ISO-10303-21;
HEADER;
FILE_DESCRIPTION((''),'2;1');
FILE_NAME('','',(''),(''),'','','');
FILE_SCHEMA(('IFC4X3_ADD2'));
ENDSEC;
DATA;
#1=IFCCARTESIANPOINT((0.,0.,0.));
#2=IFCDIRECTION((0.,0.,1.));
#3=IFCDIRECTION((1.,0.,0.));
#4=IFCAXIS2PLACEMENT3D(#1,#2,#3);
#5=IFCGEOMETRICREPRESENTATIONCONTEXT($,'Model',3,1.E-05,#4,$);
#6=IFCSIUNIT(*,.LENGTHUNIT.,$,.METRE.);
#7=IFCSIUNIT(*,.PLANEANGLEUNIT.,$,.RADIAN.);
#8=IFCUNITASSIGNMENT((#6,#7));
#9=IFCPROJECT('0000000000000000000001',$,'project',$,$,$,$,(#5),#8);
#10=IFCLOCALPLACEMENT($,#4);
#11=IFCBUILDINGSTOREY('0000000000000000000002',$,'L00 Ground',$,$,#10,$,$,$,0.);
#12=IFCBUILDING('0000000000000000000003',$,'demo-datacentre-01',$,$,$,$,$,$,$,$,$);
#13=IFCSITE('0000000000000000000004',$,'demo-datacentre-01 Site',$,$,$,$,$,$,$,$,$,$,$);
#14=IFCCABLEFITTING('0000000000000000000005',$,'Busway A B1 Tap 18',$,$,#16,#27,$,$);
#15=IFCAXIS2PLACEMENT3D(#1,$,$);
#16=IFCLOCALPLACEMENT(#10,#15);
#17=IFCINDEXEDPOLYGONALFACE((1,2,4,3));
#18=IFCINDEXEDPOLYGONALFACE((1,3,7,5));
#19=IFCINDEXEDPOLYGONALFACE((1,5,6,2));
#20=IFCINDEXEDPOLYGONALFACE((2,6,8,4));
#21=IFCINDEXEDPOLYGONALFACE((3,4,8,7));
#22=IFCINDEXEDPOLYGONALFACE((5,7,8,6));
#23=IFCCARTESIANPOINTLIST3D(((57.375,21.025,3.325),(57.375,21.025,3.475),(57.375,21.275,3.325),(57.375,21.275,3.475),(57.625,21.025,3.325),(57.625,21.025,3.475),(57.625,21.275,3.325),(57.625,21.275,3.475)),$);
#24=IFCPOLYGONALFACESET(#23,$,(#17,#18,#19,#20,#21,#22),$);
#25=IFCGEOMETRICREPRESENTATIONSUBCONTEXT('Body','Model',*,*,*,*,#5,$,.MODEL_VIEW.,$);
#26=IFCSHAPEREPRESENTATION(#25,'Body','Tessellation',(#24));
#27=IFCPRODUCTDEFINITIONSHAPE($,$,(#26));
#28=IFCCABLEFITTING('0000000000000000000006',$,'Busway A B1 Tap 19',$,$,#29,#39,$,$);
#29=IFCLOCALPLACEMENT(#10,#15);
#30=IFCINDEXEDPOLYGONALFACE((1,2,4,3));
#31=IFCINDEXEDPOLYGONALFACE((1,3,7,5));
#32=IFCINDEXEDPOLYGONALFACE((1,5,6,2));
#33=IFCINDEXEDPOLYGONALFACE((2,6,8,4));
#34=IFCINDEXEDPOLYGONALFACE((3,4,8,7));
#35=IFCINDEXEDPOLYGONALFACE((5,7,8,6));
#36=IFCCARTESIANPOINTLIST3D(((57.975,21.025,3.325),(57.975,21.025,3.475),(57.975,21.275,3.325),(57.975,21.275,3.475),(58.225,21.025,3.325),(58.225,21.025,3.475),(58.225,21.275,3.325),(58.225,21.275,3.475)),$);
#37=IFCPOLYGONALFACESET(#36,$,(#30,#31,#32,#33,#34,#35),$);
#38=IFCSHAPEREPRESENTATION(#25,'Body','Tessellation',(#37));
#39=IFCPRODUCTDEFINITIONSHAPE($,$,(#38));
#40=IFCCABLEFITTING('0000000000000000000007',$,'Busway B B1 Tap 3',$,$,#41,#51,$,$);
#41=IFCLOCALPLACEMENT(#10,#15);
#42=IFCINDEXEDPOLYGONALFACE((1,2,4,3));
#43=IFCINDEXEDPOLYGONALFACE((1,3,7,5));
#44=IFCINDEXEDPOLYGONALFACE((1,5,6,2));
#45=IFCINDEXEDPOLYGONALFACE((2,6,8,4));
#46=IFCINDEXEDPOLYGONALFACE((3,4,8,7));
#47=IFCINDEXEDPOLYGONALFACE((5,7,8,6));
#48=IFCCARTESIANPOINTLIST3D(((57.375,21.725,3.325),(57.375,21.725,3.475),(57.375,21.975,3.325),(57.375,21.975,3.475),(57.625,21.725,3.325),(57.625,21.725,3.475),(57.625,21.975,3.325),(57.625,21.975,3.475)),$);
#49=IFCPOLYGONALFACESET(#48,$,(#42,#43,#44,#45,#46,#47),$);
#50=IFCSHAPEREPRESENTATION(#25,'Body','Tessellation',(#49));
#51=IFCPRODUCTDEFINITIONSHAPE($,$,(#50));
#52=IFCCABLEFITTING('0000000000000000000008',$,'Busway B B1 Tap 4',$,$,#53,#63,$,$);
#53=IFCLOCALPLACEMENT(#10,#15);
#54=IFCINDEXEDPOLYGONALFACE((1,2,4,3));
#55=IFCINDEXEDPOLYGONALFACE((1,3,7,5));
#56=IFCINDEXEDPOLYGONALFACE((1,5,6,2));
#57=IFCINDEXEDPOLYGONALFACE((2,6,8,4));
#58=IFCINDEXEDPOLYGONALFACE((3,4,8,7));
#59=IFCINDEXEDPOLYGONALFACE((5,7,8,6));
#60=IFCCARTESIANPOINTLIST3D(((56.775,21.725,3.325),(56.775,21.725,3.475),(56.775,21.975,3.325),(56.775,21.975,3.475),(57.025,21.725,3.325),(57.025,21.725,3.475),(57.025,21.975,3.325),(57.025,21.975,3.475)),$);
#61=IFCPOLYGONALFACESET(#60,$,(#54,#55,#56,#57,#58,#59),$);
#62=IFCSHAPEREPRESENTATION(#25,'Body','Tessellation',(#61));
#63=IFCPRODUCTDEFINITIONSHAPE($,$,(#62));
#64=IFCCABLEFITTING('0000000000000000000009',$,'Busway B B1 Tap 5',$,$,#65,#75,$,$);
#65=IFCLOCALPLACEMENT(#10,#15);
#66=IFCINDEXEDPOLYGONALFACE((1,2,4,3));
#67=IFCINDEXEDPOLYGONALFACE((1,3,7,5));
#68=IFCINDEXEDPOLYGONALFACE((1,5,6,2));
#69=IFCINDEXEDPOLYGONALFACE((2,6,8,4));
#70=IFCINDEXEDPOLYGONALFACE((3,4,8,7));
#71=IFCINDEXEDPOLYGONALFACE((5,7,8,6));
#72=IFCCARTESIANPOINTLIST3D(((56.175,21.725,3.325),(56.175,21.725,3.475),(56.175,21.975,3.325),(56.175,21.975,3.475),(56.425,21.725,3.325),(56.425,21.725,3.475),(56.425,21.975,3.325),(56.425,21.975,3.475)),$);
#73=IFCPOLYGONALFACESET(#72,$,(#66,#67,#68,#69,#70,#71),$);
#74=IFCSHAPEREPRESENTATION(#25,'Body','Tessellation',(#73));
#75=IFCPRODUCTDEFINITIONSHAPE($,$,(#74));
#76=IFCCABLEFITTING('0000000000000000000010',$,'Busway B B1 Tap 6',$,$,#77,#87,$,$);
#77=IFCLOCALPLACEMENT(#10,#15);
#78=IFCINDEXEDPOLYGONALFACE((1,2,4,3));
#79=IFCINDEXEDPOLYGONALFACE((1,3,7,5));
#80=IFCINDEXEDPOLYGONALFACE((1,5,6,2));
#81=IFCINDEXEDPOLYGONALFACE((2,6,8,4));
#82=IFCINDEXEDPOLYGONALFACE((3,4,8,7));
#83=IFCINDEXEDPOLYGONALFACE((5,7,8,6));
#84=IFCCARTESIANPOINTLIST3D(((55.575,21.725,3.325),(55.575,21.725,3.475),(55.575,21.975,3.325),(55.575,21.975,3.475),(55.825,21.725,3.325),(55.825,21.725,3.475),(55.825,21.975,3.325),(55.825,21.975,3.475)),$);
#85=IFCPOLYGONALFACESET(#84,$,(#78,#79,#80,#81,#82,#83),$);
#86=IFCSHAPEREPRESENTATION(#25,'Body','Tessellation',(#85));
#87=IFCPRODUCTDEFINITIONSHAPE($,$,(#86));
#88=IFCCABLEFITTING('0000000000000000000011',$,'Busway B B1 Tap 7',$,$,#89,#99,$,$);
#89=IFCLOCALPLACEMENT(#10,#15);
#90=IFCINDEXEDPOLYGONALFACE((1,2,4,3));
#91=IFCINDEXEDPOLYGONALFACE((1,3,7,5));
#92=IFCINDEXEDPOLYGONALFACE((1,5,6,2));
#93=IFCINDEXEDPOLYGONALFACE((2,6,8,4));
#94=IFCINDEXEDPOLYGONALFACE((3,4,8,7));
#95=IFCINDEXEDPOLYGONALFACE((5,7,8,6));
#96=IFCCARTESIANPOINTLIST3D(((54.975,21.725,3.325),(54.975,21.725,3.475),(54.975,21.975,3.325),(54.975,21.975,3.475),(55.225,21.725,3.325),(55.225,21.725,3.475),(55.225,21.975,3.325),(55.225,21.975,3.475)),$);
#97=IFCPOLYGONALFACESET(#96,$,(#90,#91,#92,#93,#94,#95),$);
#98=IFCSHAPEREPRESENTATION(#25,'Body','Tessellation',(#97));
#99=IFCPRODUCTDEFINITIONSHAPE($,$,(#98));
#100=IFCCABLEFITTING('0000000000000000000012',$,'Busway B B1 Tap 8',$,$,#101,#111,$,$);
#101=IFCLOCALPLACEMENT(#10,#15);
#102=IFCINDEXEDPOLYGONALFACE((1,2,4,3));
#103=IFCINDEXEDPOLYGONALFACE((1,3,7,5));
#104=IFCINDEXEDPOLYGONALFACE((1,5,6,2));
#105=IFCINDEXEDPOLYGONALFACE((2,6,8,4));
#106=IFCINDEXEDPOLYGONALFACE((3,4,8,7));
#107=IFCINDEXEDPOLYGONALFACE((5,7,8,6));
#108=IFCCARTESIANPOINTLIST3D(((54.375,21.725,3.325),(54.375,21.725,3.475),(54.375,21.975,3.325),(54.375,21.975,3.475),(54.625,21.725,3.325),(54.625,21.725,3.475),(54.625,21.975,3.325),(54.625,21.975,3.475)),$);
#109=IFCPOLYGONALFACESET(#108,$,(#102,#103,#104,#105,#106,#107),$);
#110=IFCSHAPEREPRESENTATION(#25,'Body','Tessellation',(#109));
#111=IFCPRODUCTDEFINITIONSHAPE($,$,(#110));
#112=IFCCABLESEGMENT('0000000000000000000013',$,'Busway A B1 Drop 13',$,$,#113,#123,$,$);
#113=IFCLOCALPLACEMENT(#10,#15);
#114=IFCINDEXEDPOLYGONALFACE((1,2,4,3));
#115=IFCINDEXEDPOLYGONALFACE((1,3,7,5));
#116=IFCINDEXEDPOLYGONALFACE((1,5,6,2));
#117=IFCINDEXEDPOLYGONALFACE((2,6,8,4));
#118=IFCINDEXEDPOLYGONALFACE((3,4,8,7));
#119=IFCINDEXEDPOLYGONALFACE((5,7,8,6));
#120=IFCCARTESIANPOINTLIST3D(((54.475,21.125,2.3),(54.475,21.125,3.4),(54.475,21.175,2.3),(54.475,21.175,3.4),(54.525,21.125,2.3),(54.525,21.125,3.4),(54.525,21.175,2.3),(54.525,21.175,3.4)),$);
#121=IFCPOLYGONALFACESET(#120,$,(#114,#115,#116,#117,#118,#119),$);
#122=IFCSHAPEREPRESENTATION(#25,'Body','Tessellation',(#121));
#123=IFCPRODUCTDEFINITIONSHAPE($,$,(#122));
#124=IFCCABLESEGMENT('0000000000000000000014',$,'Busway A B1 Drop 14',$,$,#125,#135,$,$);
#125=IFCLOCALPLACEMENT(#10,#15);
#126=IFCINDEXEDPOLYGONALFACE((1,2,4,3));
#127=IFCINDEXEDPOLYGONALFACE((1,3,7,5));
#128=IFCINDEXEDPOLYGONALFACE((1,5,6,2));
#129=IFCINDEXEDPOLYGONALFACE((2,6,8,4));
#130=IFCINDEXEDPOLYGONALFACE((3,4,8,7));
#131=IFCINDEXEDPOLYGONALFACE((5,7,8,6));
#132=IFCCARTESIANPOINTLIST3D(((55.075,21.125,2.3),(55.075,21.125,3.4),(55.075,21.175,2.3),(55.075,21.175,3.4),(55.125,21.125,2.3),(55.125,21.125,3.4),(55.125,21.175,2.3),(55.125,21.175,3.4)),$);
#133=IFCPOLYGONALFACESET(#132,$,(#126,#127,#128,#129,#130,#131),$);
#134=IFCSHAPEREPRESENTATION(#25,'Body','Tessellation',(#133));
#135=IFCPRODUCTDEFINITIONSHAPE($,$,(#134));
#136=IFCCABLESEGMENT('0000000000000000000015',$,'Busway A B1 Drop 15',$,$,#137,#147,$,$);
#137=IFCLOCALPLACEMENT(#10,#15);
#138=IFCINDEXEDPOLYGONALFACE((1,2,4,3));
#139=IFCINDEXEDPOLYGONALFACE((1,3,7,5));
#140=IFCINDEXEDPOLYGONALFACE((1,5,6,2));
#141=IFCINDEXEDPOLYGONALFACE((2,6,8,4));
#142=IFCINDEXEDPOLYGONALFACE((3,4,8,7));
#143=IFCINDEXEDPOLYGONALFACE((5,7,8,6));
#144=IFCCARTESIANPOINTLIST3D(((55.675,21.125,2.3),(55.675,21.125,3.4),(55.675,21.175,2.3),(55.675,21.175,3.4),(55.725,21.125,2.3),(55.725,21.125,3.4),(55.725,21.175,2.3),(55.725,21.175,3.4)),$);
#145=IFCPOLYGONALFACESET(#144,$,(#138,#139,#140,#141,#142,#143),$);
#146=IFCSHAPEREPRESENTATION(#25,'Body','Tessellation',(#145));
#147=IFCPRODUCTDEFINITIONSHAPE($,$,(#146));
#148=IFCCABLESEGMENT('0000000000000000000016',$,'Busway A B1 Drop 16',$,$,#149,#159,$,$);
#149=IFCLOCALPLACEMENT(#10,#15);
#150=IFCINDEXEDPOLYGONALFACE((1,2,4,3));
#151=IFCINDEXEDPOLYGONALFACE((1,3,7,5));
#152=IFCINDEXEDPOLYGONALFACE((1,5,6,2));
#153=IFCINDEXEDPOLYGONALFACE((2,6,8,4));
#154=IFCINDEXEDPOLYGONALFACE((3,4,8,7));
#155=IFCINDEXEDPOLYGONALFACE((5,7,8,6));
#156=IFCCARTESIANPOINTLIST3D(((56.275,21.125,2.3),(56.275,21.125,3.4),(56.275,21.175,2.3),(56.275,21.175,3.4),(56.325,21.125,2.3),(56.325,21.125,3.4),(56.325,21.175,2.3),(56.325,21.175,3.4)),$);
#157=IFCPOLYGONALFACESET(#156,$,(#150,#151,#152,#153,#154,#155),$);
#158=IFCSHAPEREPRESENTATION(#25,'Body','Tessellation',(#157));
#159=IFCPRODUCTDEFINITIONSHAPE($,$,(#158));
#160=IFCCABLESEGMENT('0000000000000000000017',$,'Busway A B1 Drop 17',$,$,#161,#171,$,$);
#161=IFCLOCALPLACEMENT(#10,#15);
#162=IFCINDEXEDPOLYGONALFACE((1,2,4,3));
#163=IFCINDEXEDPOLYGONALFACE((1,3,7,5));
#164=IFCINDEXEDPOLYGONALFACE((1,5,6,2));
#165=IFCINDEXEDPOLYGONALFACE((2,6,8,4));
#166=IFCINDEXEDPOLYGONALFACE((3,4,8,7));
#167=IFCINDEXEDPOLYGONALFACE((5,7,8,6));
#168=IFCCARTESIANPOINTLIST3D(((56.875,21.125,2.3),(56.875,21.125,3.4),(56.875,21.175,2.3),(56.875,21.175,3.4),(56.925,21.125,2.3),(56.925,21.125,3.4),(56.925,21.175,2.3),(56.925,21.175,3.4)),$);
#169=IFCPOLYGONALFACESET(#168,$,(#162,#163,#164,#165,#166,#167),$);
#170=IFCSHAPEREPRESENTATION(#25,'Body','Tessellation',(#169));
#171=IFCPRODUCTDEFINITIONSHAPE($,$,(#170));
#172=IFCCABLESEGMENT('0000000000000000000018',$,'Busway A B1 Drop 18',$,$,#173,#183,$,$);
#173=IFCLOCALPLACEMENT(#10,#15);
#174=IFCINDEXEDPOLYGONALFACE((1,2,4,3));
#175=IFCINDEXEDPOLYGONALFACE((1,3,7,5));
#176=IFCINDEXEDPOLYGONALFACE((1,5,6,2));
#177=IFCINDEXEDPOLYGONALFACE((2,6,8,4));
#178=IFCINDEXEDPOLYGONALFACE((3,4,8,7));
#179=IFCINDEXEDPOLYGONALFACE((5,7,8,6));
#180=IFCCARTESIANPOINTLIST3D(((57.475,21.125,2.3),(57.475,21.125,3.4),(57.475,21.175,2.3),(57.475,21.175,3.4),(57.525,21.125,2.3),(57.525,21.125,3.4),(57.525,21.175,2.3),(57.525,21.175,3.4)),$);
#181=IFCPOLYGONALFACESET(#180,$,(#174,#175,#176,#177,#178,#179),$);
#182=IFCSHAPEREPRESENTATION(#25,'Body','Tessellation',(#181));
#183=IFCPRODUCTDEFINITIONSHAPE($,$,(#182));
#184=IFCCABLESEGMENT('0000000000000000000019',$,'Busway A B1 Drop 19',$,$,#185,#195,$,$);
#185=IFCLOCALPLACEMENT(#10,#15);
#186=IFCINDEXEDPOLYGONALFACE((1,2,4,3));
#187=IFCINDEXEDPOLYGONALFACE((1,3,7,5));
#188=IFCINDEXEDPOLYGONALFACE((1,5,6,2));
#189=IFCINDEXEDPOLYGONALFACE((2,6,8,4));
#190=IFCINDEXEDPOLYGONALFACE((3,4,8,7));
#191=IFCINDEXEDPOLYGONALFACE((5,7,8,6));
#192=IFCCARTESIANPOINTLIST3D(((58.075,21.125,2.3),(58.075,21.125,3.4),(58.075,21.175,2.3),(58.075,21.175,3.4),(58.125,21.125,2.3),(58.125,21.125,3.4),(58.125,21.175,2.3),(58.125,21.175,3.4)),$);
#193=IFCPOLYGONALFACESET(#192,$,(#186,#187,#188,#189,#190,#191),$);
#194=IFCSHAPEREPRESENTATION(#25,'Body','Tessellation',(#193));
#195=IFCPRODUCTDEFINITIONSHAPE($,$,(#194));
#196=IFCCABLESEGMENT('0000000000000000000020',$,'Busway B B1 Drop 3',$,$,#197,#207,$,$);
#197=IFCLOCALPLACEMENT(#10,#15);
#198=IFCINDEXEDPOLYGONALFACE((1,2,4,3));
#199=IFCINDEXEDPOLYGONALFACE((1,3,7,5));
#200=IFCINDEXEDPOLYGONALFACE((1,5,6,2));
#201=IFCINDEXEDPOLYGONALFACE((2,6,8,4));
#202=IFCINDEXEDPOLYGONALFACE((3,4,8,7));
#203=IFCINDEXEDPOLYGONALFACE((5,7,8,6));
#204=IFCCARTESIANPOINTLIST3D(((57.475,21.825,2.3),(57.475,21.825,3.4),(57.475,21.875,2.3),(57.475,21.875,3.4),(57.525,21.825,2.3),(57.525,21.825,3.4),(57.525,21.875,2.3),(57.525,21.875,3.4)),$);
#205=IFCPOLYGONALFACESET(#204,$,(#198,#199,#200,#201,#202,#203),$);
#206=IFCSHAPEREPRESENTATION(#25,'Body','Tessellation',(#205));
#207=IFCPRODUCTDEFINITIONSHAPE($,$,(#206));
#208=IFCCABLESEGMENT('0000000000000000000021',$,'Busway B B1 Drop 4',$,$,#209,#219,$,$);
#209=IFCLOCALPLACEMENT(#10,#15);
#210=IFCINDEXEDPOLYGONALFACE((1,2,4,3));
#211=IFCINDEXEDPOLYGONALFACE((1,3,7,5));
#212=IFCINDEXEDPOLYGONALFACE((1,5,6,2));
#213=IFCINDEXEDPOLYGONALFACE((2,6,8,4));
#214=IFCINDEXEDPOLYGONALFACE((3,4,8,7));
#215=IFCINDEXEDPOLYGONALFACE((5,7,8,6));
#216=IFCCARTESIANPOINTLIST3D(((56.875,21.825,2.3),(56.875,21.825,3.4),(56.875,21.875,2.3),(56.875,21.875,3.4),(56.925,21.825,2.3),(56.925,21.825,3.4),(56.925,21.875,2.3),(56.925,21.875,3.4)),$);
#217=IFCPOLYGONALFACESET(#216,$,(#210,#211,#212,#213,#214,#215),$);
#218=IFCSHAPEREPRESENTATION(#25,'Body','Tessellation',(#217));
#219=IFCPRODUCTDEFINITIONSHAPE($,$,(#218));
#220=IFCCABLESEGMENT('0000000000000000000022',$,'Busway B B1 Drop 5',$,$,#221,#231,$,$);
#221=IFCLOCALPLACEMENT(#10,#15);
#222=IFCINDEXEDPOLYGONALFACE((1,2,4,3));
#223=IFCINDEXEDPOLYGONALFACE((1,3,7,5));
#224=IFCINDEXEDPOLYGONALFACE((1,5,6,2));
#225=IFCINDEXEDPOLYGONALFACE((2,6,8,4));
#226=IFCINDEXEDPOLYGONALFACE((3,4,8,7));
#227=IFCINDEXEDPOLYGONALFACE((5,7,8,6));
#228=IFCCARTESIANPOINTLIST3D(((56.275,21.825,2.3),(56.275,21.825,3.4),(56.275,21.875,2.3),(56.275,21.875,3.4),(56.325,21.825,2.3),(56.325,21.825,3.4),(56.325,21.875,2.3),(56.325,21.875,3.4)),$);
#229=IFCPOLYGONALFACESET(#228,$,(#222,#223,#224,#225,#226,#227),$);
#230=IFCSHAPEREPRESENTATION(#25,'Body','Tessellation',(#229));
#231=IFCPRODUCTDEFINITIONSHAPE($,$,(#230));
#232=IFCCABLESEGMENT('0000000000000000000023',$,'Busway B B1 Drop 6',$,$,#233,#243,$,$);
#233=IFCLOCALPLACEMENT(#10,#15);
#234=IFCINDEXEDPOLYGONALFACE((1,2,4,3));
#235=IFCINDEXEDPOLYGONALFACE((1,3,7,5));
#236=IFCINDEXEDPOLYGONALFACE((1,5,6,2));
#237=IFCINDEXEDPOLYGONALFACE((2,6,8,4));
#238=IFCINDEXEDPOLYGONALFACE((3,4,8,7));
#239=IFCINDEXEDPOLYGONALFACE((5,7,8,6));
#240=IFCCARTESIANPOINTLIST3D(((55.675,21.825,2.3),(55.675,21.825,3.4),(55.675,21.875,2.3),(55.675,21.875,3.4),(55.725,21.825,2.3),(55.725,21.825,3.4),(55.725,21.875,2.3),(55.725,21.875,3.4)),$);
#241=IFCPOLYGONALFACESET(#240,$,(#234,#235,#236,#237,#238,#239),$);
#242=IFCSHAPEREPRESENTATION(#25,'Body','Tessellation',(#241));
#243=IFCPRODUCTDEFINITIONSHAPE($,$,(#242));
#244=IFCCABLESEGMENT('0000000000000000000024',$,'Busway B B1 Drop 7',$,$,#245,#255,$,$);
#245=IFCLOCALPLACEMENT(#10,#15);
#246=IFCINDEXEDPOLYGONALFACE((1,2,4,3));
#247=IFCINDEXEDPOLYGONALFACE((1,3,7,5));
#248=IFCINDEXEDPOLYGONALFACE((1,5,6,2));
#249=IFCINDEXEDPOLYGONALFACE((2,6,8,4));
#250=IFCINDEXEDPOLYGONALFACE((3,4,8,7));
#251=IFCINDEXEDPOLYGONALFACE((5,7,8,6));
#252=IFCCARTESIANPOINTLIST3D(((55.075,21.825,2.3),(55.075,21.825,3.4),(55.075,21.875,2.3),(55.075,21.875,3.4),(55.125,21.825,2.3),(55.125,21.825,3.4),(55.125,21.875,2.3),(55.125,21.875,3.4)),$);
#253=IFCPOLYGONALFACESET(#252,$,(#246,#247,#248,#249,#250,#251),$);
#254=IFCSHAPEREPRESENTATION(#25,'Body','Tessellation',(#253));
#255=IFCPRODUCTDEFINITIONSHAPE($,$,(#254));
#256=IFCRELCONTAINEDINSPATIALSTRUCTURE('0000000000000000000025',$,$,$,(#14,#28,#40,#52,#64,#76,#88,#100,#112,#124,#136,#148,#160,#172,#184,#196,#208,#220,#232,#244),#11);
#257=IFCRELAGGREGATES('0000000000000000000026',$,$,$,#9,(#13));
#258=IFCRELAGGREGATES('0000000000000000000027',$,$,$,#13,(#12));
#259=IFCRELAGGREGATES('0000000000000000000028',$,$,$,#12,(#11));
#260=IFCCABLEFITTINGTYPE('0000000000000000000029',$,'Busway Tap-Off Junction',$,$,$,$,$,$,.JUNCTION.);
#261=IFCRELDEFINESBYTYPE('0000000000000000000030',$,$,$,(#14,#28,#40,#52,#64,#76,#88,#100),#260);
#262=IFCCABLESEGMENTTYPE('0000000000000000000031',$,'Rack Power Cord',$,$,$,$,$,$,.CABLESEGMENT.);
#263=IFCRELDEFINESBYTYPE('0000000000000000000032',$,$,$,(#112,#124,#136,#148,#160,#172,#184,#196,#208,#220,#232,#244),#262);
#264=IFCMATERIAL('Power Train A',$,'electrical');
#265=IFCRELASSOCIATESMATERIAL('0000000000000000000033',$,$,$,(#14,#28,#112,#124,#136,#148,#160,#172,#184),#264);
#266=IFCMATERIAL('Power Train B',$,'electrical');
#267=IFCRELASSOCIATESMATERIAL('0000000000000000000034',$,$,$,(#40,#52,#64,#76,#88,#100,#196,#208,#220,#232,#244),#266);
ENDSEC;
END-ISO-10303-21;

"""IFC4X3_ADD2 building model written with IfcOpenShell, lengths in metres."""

from ifc_helpers import new_model, si_unit, frame, origin_with_axes, place, context, subcontext, project, spatial, rectangle, extrude, material, type_object, element, save


model = new_model("IFC4X3_ADD2")

# Units and contexts
model_context = context("Model", 3, precision=1e-05, world=origin_with_axes())
body_context = subcontext(model_context, "Body", "Model", "MODEL_VIEW")
ifc_project = project(units=[si_unit("LENGTHUNIT", "METRE"), si_unit("PLANEANGLEUNIT", "RADIAN")], contexts=[model_context])

# Site, building, storey
site = spatial("IfcSite", under=ifc_project, Name="demo-datacentre-01 Site")
building = spatial("IfcBuilding", under=site, Name="demo-datacentre-01")
storey_placement = place(None, origin_with_axes())
storey = spatial("IfcBuildingStorey", under=building, at=storey_placement, Name="L00 Ground", Elevation=0.0)

# Shared definitions
ifc_material_1 = material(Name="Power Train A", Category="electrical")
ifc_material_2 = material(Name="Power Train B", Category="electrical")

# Cable fittings
cable_fitting_type = type_object("IfcCableFittingType", Name="Busway Tap-Off Junction", PredefinedType="JUNCTION")
for number, where, z_axis, x_axis, name in (
    (1, (57.5, 21.15, 3.325), (0.0, 0.0, 1.0), (1.0, 0.0, 0.0), "Busway A B1 Tap 18"),
    (2, (58.1, 21.15, 3.325), (0.0, 0.0, 1.0), (1.0, 0.0, 0.0), "Busway A B1 Tap 19"),
):
    element("IfcCableFitting", number, at=place(storey_placement, frame(where, z_axis=z_axis, x_axis=x_axis)), inside=storey, type_object=cable_fitting_type, material=ifc_material_1, Name=name, context=body_context, shape_type="SweptSolid", body=[
        extrude(rectangle(XDim=0.25, YDim=0.25), origin_with_axes(), (0.0, 0.0, 1.0), 0.15),
    ])
for number, where, z_axis, x_axis, name in (
    (3, (57.5, 21.85, 3.325), (0.0, 0.0, 1.0), (1.0, 0.0, 0.0), "Busway B B1 Tap 3"),
    (4, (56.9, 21.85, 3.325), (0.0, 0.0, 1.0), (1.0, 0.0, 0.0), "Busway B B1 Tap 4"),
    (5, (56.3, 21.85, 3.325), (0.0, 0.0, 1.0), (1.0, 0.0, 0.0), "Busway B B1 Tap 5"),
    (6, (55.7, 21.85, 3.325), (0.0, 0.0, 1.0), (1.0, 0.0, 0.0), "Busway B B1 Tap 6"),
    (7, (55.1, 21.85, 3.325), (0.0, 0.0, 1.0), (1.0, 0.0, 0.0), "Busway B B1 Tap 7"),
    (8, (54.5, 21.85, 3.325), (0.0, 0.0, 1.0), (1.0, 0.0, 0.0), "Busway B B1 Tap 8"),
):
    element("IfcCableFitting", number, at=place(storey_placement, frame(where, z_axis=z_axis, x_axis=x_axis)), inside=storey, type_object=cable_fitting_type, material=ifc_material_2, Name=name, context=body_context, shape_type="SweptSolid", body=[
        extrude(rectangle(XDim=0.25, YDim=0.25), origin_with_axes(), (0.0, 0.0, 1.0), 0.15),
    ])

# Cable segments
cable_segment_type_1 = type_object("IfcCableSegmentType", Name="Rack Power Cord", PredefinedType="CABLESEGMENT")
for number, where, z_axis, x_axis, name in (
    (9, (54.5, 21.15, 3.4), (0.0, 0.0, -1.0), (1.0, 0.0, 0.0), "Busway A B1 Drop 13"),
    (10, (55.1, 21.15, 3.4), (0.0, 0.0, -1.0), (1.0, 0.0, 0.0), "Busway A B1 Drop 14"),
    (11, (55.7, 21.15, 3.4), (0.0, 0.0, -1.0), (1.0, 0.0, 0.0), "Busway A B1 Drop 15"),
    (12, (56.3, 21.15, 3.4), (0.0, 0.0, -1.0), (1.0, 0.0, 0.0), "Busway A B1 Drop 16"),
    (13, (56.9, 21.15, 3.4), (0.0, 0.0, -1.0), (1.0, 0.0, 0.0), "Busway A B1 Drop 17"),
    (14, (57.5, 21.15, 3.4), (0.0, 0.0, -1.0), (1.0, 0.0, 0.0), "Busway A B1 Drop 18"),
    (15, (58.1, 21.15, 3.4), (0.0, 0.0, -1.0), (1.0, 0.0, 0.0), "Busway A B1 Drop 19"),
):
    element("IfcCableSegment", number, at=place(storey_placement, frame(where, z_axis=z_axis, x_axis=x_axis)), inside=storey, type_object=cable_segment_type_1, material=ifc_material_1, Name=name, context=body_context, shape_type="SweptSolid", body=[
        extrude(rectangle(XDim=0.05, YDim=0.05), origin_with_axes(), (0.0, 0.0, 1.0), 1.1),
    ])
for number, where, z_axis, x_axis, name in (
    (16, (57.5, 21.85, 3.4), (0.0, 0.0, -1.0), (1.0, 0.0, 0.0), "Busway B B1 Drop 3"),
    (17, (56.9, 21.85, 3.4), (0.0, 0.0, -1.0), (1.0, 0.0, 0.0), "Busway B B1 Drop 4"),
    (18, (56.3, 21.85, 3.4), (0.0, 0.0, -1.0), (1.0, 0.0, 0.0), "Busway B B1 Drop 5"),
    (19, (55.7, 21.85, 3.4), (0.0, 0.0, -1.0), (1.0, 0.0, 0.0), "Busway B B1 Drop 6"),
    (20, (55.1, 21.85, 3.4), (0.0, 0.0, -1.0), (1.0, 0.0, 0.0), "Busway B B1 Drop 7"),
):
    element("IfcCableSegment", number, at=place(storey_placement, frame(where, z_axis=z_axis, x_axis=x_axis)), inside=storey, type_object=cable_segment_type_1, material=ifc_material_2, Name=name, context=body_context, shape_type="SweptSolid", body=[
        extrude(rectangle(XDim=0.05, YDim=0.05), origin_with_axes(), (0.0, 0.0, 1.0), 1.1),
    ])

save(model, "model.ifc")
